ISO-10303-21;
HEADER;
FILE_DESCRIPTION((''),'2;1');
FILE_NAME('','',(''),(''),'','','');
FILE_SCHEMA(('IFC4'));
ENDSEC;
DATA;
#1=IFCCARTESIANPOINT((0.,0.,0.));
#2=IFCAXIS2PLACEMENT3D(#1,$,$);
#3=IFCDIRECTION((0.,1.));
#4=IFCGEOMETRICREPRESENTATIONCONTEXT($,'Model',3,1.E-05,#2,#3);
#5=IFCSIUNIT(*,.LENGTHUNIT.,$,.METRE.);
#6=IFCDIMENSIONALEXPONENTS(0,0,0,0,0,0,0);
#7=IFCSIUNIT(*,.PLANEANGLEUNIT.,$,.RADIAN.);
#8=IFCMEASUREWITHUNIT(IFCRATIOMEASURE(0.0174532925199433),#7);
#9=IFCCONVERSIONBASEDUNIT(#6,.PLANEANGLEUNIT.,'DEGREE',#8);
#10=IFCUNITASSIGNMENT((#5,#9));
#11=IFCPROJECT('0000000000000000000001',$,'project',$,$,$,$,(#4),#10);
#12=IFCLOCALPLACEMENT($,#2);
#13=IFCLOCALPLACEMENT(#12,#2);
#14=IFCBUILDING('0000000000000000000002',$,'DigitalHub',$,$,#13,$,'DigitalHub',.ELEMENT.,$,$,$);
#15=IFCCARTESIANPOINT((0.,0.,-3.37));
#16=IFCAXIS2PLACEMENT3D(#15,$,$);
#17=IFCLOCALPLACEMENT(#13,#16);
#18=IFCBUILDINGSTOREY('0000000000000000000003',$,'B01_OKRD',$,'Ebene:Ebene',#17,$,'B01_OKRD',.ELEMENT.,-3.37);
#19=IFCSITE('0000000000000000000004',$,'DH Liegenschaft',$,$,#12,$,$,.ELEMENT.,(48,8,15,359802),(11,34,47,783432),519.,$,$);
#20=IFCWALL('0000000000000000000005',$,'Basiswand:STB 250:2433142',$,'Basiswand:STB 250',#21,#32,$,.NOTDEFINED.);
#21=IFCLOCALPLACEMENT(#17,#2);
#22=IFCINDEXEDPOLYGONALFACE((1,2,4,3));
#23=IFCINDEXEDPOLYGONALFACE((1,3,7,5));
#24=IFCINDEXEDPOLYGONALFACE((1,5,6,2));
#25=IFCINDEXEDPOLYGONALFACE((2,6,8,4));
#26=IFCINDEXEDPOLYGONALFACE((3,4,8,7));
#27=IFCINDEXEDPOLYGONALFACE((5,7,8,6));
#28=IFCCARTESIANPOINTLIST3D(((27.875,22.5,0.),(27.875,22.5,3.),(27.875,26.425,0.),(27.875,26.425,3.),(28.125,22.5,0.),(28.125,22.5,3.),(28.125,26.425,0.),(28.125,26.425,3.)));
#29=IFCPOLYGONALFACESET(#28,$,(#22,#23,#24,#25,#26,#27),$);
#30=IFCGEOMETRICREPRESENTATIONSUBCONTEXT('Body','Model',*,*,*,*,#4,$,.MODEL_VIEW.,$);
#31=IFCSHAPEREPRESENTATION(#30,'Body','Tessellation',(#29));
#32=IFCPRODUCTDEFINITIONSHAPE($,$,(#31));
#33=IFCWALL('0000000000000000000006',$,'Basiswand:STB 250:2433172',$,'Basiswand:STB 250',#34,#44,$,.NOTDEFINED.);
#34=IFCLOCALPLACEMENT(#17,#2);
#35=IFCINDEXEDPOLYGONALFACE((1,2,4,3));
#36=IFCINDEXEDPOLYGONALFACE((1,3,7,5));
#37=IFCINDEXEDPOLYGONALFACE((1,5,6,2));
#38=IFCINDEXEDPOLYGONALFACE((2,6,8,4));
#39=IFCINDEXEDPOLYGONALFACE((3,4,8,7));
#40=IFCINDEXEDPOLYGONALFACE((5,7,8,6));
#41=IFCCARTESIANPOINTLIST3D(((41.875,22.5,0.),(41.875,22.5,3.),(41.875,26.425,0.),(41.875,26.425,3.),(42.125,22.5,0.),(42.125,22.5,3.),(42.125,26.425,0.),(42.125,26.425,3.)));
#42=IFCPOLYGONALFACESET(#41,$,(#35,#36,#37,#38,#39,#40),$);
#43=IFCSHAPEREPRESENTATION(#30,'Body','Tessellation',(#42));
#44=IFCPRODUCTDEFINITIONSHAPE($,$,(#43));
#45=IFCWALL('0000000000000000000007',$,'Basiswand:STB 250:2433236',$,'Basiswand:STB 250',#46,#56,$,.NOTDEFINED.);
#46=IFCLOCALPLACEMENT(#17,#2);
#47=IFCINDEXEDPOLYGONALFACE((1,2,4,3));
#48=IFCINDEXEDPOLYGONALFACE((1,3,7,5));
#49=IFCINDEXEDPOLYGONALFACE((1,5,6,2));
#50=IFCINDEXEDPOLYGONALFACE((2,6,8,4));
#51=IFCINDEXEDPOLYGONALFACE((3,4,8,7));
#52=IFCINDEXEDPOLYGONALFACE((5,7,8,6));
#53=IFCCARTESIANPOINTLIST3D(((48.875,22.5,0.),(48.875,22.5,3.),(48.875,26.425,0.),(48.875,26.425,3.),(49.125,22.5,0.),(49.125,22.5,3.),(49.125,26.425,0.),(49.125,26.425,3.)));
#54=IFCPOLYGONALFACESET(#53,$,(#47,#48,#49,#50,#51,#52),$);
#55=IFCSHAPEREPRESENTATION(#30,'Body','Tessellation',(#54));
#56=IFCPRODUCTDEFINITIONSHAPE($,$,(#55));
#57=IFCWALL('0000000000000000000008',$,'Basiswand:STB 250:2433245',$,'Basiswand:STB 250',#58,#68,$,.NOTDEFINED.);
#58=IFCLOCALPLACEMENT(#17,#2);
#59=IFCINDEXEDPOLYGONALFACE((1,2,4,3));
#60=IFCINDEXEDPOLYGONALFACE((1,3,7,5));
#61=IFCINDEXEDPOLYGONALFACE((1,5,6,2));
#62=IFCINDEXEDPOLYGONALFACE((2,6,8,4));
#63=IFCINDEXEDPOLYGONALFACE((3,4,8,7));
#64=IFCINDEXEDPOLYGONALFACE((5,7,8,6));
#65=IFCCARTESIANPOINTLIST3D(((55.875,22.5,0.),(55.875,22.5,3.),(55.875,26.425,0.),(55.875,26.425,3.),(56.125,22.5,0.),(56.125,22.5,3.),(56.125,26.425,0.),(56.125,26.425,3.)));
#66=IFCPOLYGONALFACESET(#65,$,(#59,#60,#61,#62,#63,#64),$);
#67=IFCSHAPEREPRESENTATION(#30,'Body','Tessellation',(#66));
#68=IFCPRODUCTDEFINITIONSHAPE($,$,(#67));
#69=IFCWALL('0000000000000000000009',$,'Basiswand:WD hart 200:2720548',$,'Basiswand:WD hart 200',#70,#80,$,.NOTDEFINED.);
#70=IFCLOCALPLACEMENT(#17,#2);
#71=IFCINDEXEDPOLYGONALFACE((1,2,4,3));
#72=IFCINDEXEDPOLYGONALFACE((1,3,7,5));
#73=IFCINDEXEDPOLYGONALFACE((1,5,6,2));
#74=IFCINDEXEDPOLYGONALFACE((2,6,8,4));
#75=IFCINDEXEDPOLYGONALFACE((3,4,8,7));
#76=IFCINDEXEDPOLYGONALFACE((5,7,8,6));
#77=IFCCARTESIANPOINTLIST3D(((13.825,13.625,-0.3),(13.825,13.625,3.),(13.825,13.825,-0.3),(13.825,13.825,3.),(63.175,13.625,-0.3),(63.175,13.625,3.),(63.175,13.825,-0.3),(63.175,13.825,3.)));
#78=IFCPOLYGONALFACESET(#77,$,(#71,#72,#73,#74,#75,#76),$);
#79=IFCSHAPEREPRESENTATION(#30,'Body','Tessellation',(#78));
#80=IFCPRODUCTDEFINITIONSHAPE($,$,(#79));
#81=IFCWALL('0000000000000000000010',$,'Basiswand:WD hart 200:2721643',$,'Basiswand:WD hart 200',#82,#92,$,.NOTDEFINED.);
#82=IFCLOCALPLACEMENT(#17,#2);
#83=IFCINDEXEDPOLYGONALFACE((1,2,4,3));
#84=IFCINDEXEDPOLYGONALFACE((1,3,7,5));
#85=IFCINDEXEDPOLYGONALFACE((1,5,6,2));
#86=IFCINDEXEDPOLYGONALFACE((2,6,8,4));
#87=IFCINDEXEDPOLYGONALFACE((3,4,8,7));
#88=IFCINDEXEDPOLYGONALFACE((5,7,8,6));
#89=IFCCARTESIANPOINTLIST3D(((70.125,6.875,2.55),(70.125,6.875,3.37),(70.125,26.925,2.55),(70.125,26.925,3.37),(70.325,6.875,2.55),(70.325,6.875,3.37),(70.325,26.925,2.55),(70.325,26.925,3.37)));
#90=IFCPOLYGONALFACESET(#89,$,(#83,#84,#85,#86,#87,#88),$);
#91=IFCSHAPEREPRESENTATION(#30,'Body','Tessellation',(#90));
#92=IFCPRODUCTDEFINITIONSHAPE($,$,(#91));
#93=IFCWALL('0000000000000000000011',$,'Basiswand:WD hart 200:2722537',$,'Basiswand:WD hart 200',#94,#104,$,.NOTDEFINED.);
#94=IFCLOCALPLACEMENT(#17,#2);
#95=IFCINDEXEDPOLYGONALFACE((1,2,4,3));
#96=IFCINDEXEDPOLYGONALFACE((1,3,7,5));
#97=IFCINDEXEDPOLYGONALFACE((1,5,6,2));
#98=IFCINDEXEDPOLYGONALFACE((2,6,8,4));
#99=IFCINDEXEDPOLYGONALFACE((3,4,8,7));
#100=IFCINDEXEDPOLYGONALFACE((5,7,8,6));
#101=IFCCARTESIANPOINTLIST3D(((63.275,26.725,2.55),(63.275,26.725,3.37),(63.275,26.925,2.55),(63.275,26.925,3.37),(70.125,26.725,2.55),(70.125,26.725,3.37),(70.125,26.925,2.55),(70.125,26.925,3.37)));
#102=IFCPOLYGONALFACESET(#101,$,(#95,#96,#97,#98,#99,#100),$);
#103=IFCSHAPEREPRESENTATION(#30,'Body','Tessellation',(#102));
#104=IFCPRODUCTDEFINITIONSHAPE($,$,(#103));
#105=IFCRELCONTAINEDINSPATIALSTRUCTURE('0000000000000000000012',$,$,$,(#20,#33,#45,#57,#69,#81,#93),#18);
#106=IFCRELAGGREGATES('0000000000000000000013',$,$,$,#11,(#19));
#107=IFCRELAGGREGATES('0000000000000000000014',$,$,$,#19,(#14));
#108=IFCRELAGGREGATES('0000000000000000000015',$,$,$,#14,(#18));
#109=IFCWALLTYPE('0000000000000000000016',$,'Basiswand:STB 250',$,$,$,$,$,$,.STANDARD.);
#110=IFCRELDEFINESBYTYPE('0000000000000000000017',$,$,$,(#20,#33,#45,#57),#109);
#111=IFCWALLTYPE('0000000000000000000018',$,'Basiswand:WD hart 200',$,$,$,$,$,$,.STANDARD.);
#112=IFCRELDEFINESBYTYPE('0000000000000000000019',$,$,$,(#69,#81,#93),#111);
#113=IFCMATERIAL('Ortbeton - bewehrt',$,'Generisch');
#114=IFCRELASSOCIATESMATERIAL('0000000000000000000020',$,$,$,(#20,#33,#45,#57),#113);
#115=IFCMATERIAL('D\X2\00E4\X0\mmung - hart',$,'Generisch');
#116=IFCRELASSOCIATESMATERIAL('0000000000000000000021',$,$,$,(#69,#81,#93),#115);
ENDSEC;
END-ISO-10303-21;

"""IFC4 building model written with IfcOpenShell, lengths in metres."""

from ifc_helpers import new_model, entity, si_unit, converted_unit, direction, frame, origin, place, context, subcontext, project, spatial, indexed_curve, outline, extrude, material, type_object, element, save


model = new_model("IFC4")

# Units and contexts
model_context = context("Model", 3, precision=1e-05, world=origin(), true_north=direction((0.0, 1.0)))
body_context = subcontext(model_context, "Body", "Model", "MODEL_VIEW")
ifc_project = project(units=[si_unit("LENGTHUNIT", "METRE"), converted_unit("PLANEANGLEUNIT", "DEGREE", entity("IfcRatioMeasure", 0.0174532925199433), si_unit("PLANEANGLEUNIT", "RADIAN"), dimensions=[0, 0, 0, 0, 0, 0, 0])], contexts=[model_context])

# Site, building, storey
site_placement = place(None, frame((0.0, 0.0, 0.0)))
site = spatial("IfcSite", under=ifc_project, at=site_placement, Name="DH Liegenschaft", CompositionType="ELEMENT", RefLatitude=(48, 8, 15, 359802), RefLongitude=(11, 34, 47, 783432), RefElevation=519.0)
building_placement = place(site_placement, origin())
building = spatial("IfcBuilding", under=site, at=building_placement, Name="DigitalHub", LongName="DigitalHub", CompositionType="ELEMENT")
storey_placement = place(building_placement, frame((0.0, 0.0, -3.37)))
storey = spatial("IfcBuildingStorey", under=building, at=storey_placement, Name="B01_OKRD", ObjectType="Ebene:Ebene", LongName="B01_OKRD", CompositionType="ELEMENT", Elevation=-3.37)

# Walls
ifc_material_1 = material(Name="Ortbeton - bewehrt", Category="Generisch")
wall_type_1 = type_object("IfcWallType", Name="Basiswand:STB 250", PredefinedType="STANDARD")
wall_1_placement = place(storey_placement, frame((28.0, 26.425, 0.0), z_axis=(0.0, 0.0, 1.0), x_axis=(0.0, -1.0, 0.0)))
element("IfcWall", 1, at=wall_1_placement, inside=storey, type_object=wall_type_1, material=ifc_material_1, Name="Basiswand:STB 250:2433142", ObjectType="Basiswand:STB 250", PredefinedType="NOTDEFINED", context=body_context, shape_type="SweptSolid", body=[
    extrude(outline(indexed_curve([(3.925, 0.125), (0.0, 0.125), (0.0, -0.125), (3.925, -0.125), (3.925, 0.125)], self_intersect=False)), origin(), (0.0, 0.0, 1.0), 3.0),
])
for number, where, z_axis, x_axis, name in (
    (2, (42.0, 26.425, 0.0), (0.0, 0.0, 1.0), (0.0, -1.0, 0.0), "Basiswand:STB 250:2433172"),
    (3, (49.0, 26.425, 0.0), (0.0, 0.0, 1.0), (0.0, -1.0, 0.0), "Basiswand:STB 250:2433236"),
    (4, (56.0, 26.425, 0.0), (0.0, 0.0, 1.0), (0.0, -1.0, 0.0), "Basiswand:STB 250:2433245"),
):
    element("IfcWall", number, at=place(storey_placement, frame(where, z_axis=z_axis, x_axis=x_axis)), inside=storey, type_object=wall_type_1, material=ifc_material_1, Name=name, ObjectType="Basiswand:STB 250", PredefinedType="NOTDEFINED", context=body_context, shape_type="SweptSolid", body=[
        extrude(outline(indexed_curve([(3.925, 0.125), (0.0, 0.125), (0.0, -0.125), (3.925, -0.125), (3.925, 0.125)], self_intersect=False)), origin(), (0.0, 0.0, 1.0), 3.0),
    ])
ifc_material_2 = material(Name="Dämmung - hart", Category="Generisch")
wall_type_2 = type_object("IfcWallType", Name="Basiswand:WD hart 200", PredefinedType="STANDARD")
wall_2_placement = place(storey_placement, frame((63.175, 13.725, -0.3), z_axis=(0.0, 0.0, 1.0), x_axis=(-1.0, 0.0, 0.0)))
element("IfcWall", 5, at=wall_2_placement, inside=storey, type_object=wall_type_2, material=ifc_material_2, Name="Basiswand:WD hart 200:2720548", ObjectType="Basiswand:WD hart 200", PredefinedType="NOTDEFINED", context=body_context, shape_type="SweptSolid", body=[
    extrude(outline(indexed_curve([(49.35, 0.1), (0.0, 0.1), (0.0, -0.1), (49.35, -0.1), (49.35, 0.1)], self_intersect=False)), origin(), (0.0, 0.0, 1.0), 3.3),
])
wall_3_placement = place(storey_placement, frame((70.225, 6.875, 2.55), z_axis=(0.0, 0.0, 1.0), x_axis=(0.0, 1.0, 0.0)))
element("IfcWall", 6, at=wall_3_placement, inside=storey, type_object=wall_type_2, material=ifc_material_2, Name="Basiswand:WD hart 200:2721643", ObjectType="Basiswand:WD hart 200", PredefinedType="NOTDEFINED", context=body_context, shape_type="SweptSolid", body=[
    extrude(outline(indexed_curve([(20.05, 0.1), (0.0, 0.1), (0.0, -0.1), (20.05, -0.1), (20.05, 0.1)], self_intersect=False)), origin(), (0.0, 0.0, 1.0), 0.82),
])
wall_4_placement = place(storey_placement, frame((70.125, 26.825, 2.55), z_axis=(0.0, 0.0, 1.0), x_axis=(-1.0, 0.0, 0.0)))
element("IfcWall", 7, at=wall_4_placement, inside=storey, type_object=wall_type_2, material=ifc_material_2, Name="Basiswand:WD hart 200:2722537", ObjectType="Basiswand:WD hart 200", PredefinedType="NOTDEFINED", context=body_context, shape_type="SweptSolid", body=[
    extrude(outline(indexed_curve([(6.85, 0.1), (0.0, 0.1), (0.0, -0.1), (6.85, -0.1), (6.85, 0.1)], self_intersect=False)), origin(), (0.0, 0.0, 1.0), 0.82),
])

save(model, "model.ifc")
